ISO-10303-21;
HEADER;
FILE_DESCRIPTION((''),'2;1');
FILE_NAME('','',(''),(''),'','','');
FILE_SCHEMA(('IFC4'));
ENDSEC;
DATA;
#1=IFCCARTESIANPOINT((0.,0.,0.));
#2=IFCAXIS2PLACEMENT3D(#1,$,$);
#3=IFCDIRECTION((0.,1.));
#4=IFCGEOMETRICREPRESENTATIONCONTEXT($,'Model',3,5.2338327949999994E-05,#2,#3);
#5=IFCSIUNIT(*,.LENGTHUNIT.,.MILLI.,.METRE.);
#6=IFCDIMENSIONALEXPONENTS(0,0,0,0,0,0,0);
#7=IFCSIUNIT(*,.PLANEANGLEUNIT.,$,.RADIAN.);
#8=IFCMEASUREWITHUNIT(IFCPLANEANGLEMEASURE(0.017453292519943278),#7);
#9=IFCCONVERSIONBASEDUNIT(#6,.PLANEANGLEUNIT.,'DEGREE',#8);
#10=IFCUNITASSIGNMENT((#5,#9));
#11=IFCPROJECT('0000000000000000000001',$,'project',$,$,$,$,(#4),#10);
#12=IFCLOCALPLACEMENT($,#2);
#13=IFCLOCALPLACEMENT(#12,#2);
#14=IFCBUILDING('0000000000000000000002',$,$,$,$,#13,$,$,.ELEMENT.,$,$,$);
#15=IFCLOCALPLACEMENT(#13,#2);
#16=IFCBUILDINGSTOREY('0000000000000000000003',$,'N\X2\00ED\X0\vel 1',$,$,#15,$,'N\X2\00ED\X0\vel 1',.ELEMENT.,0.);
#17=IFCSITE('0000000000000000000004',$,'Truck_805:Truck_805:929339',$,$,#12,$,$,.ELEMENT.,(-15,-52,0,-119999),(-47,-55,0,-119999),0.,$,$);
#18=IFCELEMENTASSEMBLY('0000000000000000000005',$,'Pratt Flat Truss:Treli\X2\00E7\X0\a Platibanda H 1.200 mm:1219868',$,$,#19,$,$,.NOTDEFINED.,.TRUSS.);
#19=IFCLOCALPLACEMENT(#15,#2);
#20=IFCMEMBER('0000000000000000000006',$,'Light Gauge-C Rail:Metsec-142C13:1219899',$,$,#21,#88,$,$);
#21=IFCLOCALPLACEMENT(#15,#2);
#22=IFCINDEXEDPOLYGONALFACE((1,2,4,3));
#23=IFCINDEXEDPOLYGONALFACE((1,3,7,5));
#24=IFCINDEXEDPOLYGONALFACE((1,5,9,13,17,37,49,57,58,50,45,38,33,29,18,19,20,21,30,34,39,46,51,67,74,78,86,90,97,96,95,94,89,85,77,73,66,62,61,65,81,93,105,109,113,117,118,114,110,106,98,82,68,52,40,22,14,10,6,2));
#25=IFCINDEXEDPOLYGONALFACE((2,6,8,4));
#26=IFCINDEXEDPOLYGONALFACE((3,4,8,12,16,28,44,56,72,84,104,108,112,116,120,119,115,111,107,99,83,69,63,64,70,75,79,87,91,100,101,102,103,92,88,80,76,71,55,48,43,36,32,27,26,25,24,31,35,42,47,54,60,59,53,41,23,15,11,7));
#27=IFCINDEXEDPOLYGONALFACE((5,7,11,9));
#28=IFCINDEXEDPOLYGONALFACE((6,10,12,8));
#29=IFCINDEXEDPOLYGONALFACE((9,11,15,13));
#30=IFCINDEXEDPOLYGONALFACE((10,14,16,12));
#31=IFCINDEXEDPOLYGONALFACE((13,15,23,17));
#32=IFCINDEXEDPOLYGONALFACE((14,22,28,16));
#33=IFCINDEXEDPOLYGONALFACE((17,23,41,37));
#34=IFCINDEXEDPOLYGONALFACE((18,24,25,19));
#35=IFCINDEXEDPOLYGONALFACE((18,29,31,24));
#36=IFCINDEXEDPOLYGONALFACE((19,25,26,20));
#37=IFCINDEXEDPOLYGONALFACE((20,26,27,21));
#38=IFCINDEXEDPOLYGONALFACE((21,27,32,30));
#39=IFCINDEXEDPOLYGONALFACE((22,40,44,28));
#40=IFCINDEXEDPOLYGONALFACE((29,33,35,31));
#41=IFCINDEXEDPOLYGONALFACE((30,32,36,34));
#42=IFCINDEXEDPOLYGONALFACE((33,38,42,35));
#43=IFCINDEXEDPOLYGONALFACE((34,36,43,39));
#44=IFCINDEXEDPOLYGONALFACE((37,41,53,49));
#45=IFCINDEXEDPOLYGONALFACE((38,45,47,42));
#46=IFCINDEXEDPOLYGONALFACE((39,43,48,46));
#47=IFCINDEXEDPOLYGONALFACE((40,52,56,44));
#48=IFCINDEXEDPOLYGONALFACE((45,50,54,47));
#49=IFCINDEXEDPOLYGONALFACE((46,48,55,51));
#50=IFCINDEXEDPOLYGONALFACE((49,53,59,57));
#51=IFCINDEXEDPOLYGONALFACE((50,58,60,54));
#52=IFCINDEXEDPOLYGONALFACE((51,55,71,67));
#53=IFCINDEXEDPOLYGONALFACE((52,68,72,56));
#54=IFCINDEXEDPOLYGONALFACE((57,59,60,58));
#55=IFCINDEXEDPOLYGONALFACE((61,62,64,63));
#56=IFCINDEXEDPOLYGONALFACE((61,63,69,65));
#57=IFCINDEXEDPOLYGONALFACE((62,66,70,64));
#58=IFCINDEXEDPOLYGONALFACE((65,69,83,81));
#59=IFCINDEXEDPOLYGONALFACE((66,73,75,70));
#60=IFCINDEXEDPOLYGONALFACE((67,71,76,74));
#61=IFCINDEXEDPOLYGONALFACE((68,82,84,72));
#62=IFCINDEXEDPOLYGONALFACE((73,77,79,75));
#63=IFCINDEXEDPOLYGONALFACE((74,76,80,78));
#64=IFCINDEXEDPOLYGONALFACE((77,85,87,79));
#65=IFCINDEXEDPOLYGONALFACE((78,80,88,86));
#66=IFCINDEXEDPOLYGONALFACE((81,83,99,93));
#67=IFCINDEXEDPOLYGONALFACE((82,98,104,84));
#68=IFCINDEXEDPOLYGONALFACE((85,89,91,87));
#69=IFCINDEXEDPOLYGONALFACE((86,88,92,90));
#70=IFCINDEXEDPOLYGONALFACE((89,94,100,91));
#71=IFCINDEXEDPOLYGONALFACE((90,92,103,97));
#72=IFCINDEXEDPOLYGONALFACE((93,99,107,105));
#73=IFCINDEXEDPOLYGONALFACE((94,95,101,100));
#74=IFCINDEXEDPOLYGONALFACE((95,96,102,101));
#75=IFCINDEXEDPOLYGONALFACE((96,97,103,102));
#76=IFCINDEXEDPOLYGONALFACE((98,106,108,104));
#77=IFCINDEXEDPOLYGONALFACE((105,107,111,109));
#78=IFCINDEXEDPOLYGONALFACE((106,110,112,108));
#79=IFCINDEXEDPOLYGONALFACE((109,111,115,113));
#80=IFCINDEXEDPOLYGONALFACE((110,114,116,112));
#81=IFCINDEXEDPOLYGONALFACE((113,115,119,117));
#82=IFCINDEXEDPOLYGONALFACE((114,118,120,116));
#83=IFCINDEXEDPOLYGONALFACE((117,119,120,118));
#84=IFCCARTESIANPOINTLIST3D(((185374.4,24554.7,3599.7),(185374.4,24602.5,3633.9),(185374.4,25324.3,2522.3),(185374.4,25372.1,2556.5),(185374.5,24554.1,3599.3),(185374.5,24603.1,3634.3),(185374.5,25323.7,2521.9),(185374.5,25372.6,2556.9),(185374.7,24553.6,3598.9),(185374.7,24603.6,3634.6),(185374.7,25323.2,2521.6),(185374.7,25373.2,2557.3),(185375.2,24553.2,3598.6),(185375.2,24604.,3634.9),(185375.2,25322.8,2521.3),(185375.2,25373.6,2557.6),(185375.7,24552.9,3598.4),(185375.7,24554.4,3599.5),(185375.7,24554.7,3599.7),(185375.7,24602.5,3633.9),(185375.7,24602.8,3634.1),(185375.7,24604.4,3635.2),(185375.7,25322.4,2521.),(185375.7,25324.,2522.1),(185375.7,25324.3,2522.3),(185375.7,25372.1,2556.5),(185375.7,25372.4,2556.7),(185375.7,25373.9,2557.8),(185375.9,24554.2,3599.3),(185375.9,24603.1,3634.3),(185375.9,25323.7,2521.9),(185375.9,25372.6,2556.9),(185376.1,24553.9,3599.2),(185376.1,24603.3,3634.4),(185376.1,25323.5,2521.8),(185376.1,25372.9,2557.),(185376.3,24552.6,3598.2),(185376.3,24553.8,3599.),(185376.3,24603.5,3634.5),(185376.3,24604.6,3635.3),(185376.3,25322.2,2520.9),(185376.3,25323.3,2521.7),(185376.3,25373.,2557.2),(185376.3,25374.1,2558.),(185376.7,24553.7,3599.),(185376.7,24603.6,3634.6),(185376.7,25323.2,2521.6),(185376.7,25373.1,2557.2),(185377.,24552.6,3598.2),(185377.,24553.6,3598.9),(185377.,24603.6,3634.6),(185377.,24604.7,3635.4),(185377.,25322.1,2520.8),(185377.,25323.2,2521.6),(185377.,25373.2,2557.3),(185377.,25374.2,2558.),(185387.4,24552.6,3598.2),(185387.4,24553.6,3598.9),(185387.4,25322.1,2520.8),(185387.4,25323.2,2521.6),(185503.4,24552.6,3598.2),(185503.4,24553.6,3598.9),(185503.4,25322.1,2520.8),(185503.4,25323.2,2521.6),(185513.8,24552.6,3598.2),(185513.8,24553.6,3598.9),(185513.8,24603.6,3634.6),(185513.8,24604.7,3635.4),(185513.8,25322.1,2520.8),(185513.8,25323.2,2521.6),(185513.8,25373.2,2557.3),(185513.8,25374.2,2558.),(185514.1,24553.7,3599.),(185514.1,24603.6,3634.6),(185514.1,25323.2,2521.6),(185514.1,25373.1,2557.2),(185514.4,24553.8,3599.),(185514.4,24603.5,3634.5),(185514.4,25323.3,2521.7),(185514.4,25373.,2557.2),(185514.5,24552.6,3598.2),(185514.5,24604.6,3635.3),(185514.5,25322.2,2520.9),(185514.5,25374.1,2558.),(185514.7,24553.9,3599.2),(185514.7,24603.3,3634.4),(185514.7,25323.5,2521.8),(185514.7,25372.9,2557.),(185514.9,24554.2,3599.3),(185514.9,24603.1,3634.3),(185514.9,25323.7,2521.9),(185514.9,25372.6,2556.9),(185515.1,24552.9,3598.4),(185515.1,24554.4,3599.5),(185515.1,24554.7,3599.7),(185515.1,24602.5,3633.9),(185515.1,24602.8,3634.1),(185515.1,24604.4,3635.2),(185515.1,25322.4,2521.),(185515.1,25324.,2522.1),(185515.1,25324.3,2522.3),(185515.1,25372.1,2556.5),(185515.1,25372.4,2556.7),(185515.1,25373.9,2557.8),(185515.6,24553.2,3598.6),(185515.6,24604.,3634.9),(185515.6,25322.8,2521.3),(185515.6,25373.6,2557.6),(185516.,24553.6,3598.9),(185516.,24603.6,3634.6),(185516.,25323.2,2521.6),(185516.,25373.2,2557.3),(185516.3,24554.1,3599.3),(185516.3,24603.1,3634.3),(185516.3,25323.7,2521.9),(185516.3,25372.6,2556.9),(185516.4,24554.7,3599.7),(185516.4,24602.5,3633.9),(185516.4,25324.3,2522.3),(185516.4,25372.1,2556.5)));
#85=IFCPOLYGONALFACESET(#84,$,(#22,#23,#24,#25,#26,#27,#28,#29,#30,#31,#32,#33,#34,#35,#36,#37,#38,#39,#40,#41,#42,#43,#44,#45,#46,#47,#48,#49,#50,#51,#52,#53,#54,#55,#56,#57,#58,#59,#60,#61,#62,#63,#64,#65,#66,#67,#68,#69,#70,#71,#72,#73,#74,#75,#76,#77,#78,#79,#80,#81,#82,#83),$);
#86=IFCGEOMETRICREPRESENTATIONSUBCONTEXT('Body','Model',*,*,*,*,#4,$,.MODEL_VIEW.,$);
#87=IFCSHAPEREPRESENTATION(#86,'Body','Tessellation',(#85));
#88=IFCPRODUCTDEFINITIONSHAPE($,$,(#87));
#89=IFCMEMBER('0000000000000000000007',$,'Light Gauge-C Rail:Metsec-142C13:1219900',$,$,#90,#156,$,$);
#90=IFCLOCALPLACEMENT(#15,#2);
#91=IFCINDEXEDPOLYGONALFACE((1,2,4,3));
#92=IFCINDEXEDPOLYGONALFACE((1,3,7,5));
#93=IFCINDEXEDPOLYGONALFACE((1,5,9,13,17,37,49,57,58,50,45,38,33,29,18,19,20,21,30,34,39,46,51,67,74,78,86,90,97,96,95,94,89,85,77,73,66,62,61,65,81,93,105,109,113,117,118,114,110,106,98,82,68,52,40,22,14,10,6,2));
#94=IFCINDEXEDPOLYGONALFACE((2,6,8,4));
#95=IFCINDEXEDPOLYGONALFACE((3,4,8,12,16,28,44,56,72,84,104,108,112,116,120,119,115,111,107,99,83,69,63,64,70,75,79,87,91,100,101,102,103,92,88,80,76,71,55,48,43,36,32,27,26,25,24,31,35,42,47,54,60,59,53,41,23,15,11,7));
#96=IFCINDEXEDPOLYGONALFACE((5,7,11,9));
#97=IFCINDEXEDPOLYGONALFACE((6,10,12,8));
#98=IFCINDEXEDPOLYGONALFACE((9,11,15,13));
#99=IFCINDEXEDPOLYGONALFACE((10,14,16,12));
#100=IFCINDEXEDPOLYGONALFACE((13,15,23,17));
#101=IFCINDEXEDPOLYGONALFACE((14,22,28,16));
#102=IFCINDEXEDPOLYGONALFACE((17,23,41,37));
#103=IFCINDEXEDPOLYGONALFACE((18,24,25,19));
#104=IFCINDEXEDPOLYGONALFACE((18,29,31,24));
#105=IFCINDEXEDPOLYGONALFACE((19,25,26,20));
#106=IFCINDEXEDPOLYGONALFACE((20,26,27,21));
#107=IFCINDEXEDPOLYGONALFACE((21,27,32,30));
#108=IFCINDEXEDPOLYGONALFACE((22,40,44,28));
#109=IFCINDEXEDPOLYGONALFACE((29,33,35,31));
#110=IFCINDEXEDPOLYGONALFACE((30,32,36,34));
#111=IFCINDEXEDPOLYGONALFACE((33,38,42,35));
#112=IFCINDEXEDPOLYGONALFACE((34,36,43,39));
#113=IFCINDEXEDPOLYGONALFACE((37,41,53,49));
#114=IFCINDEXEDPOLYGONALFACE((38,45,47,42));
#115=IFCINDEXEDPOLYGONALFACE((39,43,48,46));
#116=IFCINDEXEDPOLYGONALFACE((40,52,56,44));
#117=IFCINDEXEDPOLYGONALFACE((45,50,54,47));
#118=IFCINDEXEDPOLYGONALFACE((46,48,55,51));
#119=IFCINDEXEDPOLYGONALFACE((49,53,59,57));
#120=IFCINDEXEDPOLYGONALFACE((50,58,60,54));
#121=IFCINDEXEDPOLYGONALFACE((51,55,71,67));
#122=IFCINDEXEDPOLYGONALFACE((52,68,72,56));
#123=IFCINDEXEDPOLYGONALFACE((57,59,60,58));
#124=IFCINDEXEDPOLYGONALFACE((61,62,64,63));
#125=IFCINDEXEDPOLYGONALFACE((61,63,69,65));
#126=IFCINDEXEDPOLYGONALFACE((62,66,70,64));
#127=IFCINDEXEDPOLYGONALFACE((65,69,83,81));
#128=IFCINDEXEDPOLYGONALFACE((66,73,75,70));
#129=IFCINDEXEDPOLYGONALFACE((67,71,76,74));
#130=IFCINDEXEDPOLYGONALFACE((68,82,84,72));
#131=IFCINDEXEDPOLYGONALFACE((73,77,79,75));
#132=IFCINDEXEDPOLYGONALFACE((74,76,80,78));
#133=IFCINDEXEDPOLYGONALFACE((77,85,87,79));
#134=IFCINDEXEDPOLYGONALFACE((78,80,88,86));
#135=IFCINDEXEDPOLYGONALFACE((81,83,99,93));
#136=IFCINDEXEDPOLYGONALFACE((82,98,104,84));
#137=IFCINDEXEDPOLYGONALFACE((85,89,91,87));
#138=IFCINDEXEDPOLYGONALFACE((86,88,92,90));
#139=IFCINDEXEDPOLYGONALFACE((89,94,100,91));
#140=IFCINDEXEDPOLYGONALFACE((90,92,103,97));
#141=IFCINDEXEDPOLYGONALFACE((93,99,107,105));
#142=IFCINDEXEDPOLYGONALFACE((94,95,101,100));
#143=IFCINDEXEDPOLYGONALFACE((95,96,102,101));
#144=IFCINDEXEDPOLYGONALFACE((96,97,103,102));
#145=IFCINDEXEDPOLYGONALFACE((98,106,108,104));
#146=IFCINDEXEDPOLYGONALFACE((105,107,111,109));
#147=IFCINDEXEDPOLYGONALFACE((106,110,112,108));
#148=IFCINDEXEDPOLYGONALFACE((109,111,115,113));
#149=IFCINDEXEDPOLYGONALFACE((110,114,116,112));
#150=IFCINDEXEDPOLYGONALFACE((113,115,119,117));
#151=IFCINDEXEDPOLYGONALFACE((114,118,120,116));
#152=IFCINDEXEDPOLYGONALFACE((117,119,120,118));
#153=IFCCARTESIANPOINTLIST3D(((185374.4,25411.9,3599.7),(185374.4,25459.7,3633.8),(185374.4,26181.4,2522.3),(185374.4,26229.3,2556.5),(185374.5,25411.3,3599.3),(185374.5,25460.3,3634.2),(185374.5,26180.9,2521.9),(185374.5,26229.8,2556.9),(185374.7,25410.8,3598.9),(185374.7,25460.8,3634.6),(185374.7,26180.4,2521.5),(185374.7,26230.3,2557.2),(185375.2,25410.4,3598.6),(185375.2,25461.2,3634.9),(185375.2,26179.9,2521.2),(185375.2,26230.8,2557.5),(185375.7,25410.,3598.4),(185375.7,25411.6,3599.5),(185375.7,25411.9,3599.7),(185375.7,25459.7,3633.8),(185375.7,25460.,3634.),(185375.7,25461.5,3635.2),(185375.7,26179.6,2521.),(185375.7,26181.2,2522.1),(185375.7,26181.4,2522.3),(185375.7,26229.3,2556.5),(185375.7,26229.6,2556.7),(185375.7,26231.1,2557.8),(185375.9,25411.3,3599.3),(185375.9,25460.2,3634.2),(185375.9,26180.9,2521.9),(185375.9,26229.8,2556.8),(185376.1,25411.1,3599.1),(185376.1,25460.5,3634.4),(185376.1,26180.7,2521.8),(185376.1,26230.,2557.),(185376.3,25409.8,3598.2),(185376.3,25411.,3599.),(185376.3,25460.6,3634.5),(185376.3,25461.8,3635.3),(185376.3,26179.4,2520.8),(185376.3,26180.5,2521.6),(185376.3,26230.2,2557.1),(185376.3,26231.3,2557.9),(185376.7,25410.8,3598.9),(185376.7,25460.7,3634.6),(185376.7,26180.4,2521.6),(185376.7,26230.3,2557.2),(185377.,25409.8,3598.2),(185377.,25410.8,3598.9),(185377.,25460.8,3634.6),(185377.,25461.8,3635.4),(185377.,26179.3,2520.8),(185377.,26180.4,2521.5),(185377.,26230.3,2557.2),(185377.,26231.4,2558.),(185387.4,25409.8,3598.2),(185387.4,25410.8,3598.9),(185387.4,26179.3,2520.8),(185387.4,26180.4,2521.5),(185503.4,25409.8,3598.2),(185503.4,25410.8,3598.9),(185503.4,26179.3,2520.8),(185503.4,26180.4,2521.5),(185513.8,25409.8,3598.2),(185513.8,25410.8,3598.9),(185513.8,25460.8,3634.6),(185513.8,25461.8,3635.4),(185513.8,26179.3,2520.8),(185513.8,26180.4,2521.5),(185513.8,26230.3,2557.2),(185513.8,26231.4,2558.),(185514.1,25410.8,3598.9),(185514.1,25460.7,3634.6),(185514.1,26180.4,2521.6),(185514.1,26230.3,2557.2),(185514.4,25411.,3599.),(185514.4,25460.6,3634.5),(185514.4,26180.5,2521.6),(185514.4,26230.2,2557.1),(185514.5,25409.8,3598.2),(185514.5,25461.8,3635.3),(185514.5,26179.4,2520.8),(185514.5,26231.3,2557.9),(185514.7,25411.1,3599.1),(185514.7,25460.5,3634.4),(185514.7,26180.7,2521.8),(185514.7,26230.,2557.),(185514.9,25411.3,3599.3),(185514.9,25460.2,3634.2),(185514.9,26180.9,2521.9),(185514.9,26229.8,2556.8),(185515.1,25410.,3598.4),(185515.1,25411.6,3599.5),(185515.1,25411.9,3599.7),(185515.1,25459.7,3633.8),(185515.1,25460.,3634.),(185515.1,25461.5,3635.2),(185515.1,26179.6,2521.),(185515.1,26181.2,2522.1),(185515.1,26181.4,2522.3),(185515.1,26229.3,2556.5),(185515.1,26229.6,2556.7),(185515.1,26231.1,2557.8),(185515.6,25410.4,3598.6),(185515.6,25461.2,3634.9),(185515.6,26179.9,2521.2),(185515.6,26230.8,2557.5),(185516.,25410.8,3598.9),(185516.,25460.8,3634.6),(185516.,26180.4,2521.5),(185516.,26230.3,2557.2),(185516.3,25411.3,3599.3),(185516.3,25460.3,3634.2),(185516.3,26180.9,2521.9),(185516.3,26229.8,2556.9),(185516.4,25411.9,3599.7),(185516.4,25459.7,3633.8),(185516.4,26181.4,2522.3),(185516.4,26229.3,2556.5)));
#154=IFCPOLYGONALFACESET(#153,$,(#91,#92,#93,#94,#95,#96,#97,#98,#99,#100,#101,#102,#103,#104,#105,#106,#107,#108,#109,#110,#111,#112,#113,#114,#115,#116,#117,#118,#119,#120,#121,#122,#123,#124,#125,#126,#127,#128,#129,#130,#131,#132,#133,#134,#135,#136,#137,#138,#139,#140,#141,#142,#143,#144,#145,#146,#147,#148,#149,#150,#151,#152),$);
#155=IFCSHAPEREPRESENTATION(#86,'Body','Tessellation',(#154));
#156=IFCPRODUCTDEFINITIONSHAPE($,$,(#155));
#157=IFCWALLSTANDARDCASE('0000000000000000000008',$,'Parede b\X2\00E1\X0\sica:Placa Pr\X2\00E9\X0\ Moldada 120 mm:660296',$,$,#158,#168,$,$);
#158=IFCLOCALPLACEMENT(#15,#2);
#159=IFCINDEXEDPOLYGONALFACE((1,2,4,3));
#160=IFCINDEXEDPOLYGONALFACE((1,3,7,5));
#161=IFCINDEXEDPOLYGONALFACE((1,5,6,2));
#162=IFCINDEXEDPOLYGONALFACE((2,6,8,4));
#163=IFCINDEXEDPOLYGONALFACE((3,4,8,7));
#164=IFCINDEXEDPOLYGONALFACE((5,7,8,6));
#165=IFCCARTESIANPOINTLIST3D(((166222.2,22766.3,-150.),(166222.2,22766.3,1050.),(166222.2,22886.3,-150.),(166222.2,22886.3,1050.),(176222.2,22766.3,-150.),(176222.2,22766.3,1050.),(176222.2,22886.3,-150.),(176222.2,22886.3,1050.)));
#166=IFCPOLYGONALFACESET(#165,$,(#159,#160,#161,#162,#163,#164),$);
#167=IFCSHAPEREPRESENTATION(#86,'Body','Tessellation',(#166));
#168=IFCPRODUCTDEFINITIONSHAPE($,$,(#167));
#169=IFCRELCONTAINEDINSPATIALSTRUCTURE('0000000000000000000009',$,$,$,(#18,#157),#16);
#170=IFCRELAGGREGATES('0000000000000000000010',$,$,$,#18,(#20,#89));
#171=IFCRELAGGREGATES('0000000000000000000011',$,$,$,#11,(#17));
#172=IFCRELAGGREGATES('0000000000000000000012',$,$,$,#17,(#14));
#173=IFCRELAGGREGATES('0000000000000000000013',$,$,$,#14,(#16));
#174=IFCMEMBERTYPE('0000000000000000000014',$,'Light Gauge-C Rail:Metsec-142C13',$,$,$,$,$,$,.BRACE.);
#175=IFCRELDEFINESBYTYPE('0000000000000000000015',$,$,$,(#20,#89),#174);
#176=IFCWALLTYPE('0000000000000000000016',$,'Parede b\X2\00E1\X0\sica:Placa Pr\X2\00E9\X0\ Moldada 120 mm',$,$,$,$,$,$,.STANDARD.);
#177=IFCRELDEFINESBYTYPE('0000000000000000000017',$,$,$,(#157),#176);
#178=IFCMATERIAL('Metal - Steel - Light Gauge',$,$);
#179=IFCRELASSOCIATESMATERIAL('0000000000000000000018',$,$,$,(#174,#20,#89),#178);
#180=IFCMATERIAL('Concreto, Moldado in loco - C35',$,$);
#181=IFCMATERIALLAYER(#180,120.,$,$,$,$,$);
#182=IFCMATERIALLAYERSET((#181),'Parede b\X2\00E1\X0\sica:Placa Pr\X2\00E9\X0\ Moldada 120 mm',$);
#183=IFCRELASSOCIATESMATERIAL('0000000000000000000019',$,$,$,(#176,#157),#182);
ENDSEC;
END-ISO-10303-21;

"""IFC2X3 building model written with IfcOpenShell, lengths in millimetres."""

from ifc_helpers import new_model, entity, si_unit, converted_unit, direction, frame, frame_2d, origin, place, context, subcontext, project, spatial, polyline, circle_curve, parameter, trimmed, segment, composite_curve, rectangle, outline, extrude, source, transform, mapped, material, layer, layer_set, layer_usage, type_object, type_shapes, element, aggregate, save


model = new_model("IFC2X3")

# Units and contexts
model_context = context("Model", 3, precision=5.2338327949999994e-05, world=origin(), true_north=direction((0.0, 1.0)))
body_context = subcontext(model_context, "Body", "Model", "MODEL_VIEW")
ifc_project = project(units=[si_unit("LENGTHUNIT", "METRE", prefix="MILLI"), converted_unit("PLANEANGLEUNIT", "DEGREE", entity("IfcPlaneAngleMeasure", 0.017453292519943278), si_unit("PLANEANGLEUNIT", "RADIAN"), dimensions=[0, 0, 0, 0, 0, 0, 0])], contexts=[model_context])

# Site, building, storey
site_placement = place(None, origin())
site = spatial("IfcSite", under=ifc_project, at=site_placement, Name="Truck_805:Truck_805:929339", CompositionType="ELEMENT", RefLatitude=(-15, -52, 0, -119999), RefLongitude=(-47, -55, 0, -119999), RefElevation=0.0)
building_placement = place(site_placement, origin())
building = spatial("IfcBuilding", under=site, at=building_placement, CompositionType="ELEMENT")
storey_placement = place(building_placement, origin())
storey = spatial("IfcBuildingStorey", under=building, at=storey_placement, Name="Nível 1", LongName="Nível 1", CompositionType="ELEMENT", Elevation=0.0)

# Shared definitions
ifc_material_1 = material(Name="Metal - Steel - Light Gauge")

# Element assembly, members
assembly_placement = place(storey_placement, origin())
assembly = element("IfcElementAssembly", 1, at=assembly_placement, inside=storey, Name="Pratt Flat Truss:Treliça Platibanda H 1.200 mm:1219868", AssemblyPlace="NOTDEFINED", PredefinedType="TRUSS")
member_type_1 = type_object("IfcMemberType", Name="Light Gauge-C Rail:Metsec-142C13", PredefinedType="BRACE", material=ifc_material_1)
shared_shape_1 = source(origin(), body_context, "Body", "SweptSolid", [
    extrude(outline(composite_curve([segment(polyline([(-23.1, -71.0), (35.7, -71.0)]), True, "CONTINUOUS"), segment(trimmed(circle_curve(frame_2d((35.7, -68.4), x_axis=(0.0, -1.0)), 2.6), [parameter(0.0)], [parameter(90.0)], True, "PARAMETER"), True, "CONTINUOUS"), segment(polyline([(38.3, -68.4), (38.3, 68.4)]), True, "CONTINUOUS"), segment(trimmed(circle_curve(frame_2d((35.7, 68.4), x_axis=(1.0, 0.0)), 2.6), [parameter(0.0)], [parameter(90.0)], True, "PARAMETER"), True, "CONTINUOUS"), segment(polyline([(35.7, 71.0), (-23.1, 71.0)]), True, "CONTINUOUS"), segment(trimmed(circle_curve(frame_2d((-23.1, 68.4), x_axis=(0.0, 1.0)), 2.6), [parameter(0.0)], [parameter(90.0)], True, "PARAMETER"), True, "CONTINUOUS"), segment(polyline([(-25.7, 68.4), (-25.7, 58.0)]), True, "CONTINUOUS"), segment(polyline([(-25.7, 58.0), (-24.4, 58.0)]), True, "CONTINUOUS"), segment(polyline([(-24.4, 58.0), (-24.4, 68.4)]), True, "CONTINUOUS"), segment(trimmed(circle_curve(frame_2d((-23.1, 68.4), x_axis=(-1.0, 0.0)), 1.3), [parameter(270.0)], [parameter(0.0)], True, "PARAMETER"), False, "CONTINUOUS"), segment(polyline([(-23.1, 69.7), (35.7, 69.7)]), True, "CONTINUOUS"), segment(trimmed(circle_curve(frame_2d((35.7, 68.4), x_axis=(0.0, 1.0)), 1.3), [parameter(270.0)], [parameter(0.0)], True, "PARAMETER"), False, "CONTINUOUS"), segment(polyline([(37.0, 68.4), (37.0, -68.4)]), True, "CONTINUOUS"), segment(trimmed(circle_curve(frame_2d((35.7, -68.4), x_axis=(1.0, 0.0)), 1.3), [parameter(270.0)], [parameter(0.0)], True, "PARAMETER"), False, "CONTINUOUS"), segment(polyline([(35.7, -69.7), (-23.1, -69.7)]), True, "CONTINUOUS"), segment(trimmed(circle_curve(frame_2d((-23.1, -68.4), x_axis=(0.0, -1.0)), 1.3), [parameter(270.0)], [parameter(0.0)], True, "PARAMETER"), False, "CONTINUOUS"), segment(polyline([(-24.4, -68.4), (-24.4, -58.0)]), True, "CONTINUOUS"), segment(polyline([(-24.4, -58.0), (-25.7, -58.0)]), True, "CONTINUOUS"), segment(polyline([(-25.7, -58.0), (-25.7, -68.4)]), True, "CONTINUOUS"), segment(trimmed(circle_curve(frame_2d((-23.1, -68.4), x_axis=(-1.0, 0.0)), 2.6), [parameter(0.0)], [parameter(90.0)], True, "PARAMETER"), True, "CONTINUOUS")], self_intersect=False)), frame((-653.0, 0.0, 18.8), z_axis=(1.0, 0.0, 0.0), x_axis=(0.0, 0.0, -1.0)), (0.0, 0.0, 1.0), 1324.0),
])
type_shapes(member_type_1, [shared_shape_1])
member_1_placement = place(assembly_placement, frame((185445.4, 24978.8, 3078.0), z_axis=(0.0, -0.81373, -0.581243), x_axis=(0.0, -0.581243, 0.81373)))
member_1 = element("IfcMember", 2, at=member_1_placement, type_object=member_type_1, material=ifc_material_1, Name="Light Gauge-C Rail:Metsec-142C13:1219899", context=body_context, shape_type="MappedRepresentation", body=[
    mapped(shared_shape_1, transform((0.0, 0.0, 0.0), scale=1.0)),
])
member_2_placement = place(assembly_placement, frame((185445.4, 25836.0, 3078.0), z_axis=(0.0, -0.81373, -0.581243), x_axis=(0.0, -0.581243, 0.81373)))
member_2 = element("IfcMember", 3, at=member_2_placement, type_object=member_type_1, material=ifc_material_1, Name="Light Gauge-C Rail:Metsec-142C13:1219900", context=body_context, shape_type="MappedRepresentation", body=[
    mapped(shared_shape_1, transform((0.0, 0.0, 0.0), scale=1.0)),
])
aggregate(assembly, [member_1, member_2])

# Wall
ifc_material_2 = material(Name="Concreto, Moldado in loco - C35")
ifc_layer_1 = layer(ifc_material_2, 120.0)
ifc_layer_set_1 = layer_set([ifc_layer_1], Name="Parede básica:Placa Pré Moldada 120 mm")
ifc_layer_usage_1 = layer_usage(ifc_layer_set_1, "AXIS2", "NEGATIVE", 60.0)
wall_type_1 = type_object("IfcWallType", Name="Parede básica:Placa Pré Moldada 120 mm", PredefinedType="STANDARD", material=ifc_layer_set_1)
wall_1_placement = place(storey_placement, frame((166222.2, 22826.3, -150.0)))
element("IfcWallStandardCase", 4, at=wall_1_placement, inside=storey, type_object=wall_type_1, material=ifc_layer_usage_1, Name="Parede básica:Placa Pré Moldada 120 mm:660296", context=body_context, shape_type="SweptSolid", body=[
    extrude(rectangle(XDim=10000.0, YDim=120.0, at=frame_2d((5000.0, 0.0), x_axis=(-1.0, 0.0))), origin(), (0.0, 0.0, 1.0), 1200.0),
])

save(model, "model.ifc")
